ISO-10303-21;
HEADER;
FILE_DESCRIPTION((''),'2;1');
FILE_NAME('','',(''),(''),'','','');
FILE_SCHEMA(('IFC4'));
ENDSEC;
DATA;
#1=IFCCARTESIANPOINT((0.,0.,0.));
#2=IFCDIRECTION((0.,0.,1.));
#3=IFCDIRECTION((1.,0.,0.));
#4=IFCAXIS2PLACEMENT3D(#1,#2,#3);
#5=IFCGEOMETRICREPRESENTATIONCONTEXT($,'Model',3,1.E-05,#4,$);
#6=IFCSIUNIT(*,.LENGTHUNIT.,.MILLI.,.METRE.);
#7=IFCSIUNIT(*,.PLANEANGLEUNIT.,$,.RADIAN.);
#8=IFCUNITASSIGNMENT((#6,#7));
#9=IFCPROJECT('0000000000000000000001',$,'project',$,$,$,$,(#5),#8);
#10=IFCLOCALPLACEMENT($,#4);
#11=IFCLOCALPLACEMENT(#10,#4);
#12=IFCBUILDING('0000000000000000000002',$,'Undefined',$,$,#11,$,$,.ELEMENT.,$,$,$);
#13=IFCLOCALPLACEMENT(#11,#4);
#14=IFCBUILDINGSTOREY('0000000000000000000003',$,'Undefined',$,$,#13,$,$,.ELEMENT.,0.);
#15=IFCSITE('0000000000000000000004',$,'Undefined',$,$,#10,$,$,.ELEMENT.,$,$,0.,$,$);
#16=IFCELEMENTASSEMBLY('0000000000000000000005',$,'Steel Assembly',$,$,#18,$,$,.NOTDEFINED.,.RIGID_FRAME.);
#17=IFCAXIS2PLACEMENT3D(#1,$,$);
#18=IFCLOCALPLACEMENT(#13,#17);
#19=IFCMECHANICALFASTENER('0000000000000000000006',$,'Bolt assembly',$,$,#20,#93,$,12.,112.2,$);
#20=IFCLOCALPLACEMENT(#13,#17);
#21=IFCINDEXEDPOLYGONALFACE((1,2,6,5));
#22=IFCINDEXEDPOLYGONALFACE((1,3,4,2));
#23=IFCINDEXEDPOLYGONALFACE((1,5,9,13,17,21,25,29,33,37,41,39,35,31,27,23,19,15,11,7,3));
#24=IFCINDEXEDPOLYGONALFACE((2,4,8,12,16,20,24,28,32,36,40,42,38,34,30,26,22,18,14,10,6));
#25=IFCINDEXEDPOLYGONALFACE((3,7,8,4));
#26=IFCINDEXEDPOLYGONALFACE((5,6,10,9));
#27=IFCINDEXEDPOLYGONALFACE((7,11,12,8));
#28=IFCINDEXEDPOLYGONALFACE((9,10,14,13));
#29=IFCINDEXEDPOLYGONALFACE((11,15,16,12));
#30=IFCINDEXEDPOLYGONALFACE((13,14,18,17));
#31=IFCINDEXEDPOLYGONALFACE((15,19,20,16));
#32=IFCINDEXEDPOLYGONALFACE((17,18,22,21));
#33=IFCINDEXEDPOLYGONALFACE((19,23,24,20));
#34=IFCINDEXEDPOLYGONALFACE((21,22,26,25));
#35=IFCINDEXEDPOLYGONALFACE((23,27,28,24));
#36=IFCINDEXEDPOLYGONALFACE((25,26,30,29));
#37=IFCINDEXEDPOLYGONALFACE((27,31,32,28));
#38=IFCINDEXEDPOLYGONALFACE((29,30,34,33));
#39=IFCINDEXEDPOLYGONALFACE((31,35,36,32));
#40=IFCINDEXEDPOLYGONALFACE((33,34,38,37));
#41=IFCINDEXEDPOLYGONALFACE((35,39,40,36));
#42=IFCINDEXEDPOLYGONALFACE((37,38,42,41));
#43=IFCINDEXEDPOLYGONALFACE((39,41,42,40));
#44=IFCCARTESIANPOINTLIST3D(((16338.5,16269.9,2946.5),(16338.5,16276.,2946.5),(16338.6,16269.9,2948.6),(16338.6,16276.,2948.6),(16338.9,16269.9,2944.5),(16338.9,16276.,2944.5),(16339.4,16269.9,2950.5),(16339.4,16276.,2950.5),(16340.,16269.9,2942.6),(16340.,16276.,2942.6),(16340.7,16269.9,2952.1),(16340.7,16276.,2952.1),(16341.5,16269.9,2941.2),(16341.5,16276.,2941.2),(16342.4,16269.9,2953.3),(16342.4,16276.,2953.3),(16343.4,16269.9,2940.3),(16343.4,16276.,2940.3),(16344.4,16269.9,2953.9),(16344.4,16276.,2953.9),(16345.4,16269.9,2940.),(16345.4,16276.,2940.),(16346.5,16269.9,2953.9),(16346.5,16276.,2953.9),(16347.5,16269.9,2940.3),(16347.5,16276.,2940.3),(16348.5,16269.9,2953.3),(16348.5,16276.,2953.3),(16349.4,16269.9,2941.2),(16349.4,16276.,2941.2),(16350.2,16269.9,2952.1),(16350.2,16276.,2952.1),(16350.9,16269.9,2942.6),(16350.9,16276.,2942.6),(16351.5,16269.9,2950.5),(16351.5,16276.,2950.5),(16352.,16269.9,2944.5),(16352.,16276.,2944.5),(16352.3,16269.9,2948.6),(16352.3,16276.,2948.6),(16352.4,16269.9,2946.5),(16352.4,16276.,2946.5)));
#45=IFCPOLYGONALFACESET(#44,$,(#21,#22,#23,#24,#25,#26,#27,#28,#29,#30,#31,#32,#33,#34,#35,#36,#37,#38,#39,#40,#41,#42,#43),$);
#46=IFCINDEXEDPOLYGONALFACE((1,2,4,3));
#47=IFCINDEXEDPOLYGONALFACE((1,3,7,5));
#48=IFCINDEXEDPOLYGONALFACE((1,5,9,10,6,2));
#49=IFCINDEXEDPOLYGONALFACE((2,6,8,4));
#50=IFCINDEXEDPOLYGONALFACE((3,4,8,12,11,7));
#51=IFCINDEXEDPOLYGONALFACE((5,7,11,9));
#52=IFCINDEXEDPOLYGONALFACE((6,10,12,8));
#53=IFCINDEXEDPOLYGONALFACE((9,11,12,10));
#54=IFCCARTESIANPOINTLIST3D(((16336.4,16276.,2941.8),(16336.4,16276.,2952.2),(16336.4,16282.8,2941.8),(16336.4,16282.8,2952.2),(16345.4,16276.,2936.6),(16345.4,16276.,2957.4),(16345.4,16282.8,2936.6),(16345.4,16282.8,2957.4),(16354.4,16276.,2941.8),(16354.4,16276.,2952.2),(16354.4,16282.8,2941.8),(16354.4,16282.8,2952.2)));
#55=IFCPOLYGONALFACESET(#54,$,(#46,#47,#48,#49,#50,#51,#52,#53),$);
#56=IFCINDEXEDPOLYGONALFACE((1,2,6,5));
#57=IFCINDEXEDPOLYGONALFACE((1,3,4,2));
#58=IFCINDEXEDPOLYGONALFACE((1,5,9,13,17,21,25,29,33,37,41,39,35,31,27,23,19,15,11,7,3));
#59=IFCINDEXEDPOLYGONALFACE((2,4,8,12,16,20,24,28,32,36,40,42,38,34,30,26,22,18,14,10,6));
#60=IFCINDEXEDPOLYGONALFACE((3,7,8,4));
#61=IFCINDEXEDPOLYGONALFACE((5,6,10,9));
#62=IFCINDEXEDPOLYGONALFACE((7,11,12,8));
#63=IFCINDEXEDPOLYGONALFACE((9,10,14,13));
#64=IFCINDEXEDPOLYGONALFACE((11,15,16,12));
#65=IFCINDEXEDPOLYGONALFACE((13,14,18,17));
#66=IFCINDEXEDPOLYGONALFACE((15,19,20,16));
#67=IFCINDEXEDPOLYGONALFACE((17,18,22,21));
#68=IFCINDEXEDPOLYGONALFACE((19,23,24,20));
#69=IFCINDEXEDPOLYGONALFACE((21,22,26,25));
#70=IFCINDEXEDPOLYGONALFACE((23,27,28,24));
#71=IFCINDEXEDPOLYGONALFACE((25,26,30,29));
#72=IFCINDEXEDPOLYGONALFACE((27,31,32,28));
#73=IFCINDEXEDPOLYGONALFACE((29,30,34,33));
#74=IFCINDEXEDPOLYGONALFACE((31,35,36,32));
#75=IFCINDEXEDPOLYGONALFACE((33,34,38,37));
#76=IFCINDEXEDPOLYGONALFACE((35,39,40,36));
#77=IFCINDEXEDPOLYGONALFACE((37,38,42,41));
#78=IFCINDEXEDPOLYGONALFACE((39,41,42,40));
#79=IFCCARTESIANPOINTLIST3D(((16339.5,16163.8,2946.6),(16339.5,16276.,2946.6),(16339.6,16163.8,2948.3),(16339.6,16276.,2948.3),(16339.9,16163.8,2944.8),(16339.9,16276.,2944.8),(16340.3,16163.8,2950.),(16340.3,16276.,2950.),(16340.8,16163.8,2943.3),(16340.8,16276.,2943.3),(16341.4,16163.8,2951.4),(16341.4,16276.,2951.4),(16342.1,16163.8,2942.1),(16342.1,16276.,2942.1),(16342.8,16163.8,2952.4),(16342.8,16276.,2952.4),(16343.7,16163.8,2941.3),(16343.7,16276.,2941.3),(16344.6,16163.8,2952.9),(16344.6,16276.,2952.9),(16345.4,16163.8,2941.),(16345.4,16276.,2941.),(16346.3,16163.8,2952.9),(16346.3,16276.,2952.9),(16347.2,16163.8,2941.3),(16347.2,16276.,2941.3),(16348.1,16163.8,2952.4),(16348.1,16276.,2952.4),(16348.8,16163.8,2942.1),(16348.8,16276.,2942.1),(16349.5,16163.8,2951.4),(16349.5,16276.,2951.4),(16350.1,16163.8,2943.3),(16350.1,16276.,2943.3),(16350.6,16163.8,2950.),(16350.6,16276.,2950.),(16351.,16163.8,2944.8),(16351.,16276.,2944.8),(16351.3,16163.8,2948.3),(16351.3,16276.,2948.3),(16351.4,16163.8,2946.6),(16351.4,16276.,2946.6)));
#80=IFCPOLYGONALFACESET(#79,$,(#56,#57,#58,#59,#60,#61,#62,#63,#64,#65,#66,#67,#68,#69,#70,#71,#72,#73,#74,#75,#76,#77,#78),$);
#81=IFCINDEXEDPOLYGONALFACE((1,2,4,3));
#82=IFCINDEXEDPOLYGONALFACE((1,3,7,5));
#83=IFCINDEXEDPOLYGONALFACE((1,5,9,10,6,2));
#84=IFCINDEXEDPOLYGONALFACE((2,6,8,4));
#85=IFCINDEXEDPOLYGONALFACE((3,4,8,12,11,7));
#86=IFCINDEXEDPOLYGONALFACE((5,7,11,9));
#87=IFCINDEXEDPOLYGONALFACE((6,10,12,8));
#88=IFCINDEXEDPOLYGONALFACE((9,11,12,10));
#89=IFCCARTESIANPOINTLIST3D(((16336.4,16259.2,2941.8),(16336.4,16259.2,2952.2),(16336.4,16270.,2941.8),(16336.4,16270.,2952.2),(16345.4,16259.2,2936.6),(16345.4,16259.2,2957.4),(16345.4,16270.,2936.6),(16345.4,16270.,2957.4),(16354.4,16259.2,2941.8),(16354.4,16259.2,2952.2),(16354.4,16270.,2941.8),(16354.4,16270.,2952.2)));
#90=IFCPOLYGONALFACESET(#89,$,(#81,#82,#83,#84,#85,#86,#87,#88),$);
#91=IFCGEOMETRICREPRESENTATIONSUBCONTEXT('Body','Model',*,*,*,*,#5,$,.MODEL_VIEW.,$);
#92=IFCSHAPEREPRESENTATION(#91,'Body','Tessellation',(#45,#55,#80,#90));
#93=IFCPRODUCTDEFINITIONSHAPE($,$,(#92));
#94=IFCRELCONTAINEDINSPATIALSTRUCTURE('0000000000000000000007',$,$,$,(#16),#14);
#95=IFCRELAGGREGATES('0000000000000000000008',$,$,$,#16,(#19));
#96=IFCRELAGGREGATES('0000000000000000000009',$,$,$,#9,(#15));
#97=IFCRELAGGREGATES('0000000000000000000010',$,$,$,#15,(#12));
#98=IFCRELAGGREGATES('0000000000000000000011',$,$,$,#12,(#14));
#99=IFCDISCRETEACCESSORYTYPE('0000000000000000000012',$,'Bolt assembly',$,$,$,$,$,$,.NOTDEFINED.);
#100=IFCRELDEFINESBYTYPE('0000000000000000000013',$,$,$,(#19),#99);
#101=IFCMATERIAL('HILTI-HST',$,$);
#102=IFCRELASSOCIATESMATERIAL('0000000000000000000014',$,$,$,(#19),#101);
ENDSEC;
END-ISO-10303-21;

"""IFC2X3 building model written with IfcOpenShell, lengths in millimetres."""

from ifc_helpers import new_model, si_unit, frame, origin_with_axes, origin_2d_with_axis, place, context, subcontext, project, spatial, polyline, circle, outline, extrude, source, transform, mapped, material, type_object, element, aggregate, save


model = new_model("IFC2X3")

# Units and contexts
model_context = context("Model", 3, precision=1e-05, world=origin_with_axes())
body_context = subcontext(model_context, "Body", "Model", "MODEL_VIEW")
ifc_project = project(units=[si_unit("LENGTHUNIT", "METRE", prefix="MILLI"), si_unit("PLANEANGLEUNIT", "RADIAN")], contexts=[model_context])

# Site, building, storey
site_placement = place(None, origin_with_axes())
site = spatial("IfcSite", under=ifc_project, at=site_placement, Name="Undefined", CompositionType="ELEMENT", RefElevation=0.0)
building_placement = place(site_placement, origin_with_axes())
building = spatial("IfcBuilding", under=site, at=building_placement, Name="Undefined", CompositionType="ELEMENT")
storey_placement = place(building_placement, origin_with_axes())
storey = spatial("IfcBuildingStorey", under=building, at=storey_placement, Name="Undefined", CompositionType="ELEMENT", Elevation=0.0)

# Shared definitions
discrete_accessory_type_1 = type_object("IfcDiscreteAccessoryType", Name="Bolt assembly")

# Element assembly, mechanical fastener
assembly_1_placement = place(storey_placement, origin_with_axes())
assembly_1 = element("IfcElementAssembly", 1, at=assembly_1_placement, inside=storey, Name="Steel Assembly", AssemblyPlace="NOTDEFINED", PredefinedType="RIGID_FRAME")
ifc_material_1 = material(Name="HILTI-HST")
shared_shape_1 = source(origin_with_axes(), body_context, "Body", "SweptSolid", [
    extrude(circle(Radius=7.0, at=origin_2d_with_axis()), frame((0.0, 0.0, 0.0), z_axis=(0.0, 1.0, 0.0), x_axis=(1.0, 0.0, 0.0)), (0.0, 0.0, 1.0), 6.1),
    extrude(outline(polyline([(10.4, 0.0), (5.2, 9.0), (-5.2, 9.0), (-10.4, 0.0), (-5.2, -9.0), (5.2, -9.0), (10.4, 0.0)])), frame((0.0, -6.8, 0.0), z_axis=(0.0, 1.0, 0.0), x_axis=(1.0, 0.0, 0.0)), (0.0, 0.0, 1.0), 6.8),
    extrude(circle(Radius=6.0, at=origin_2d_with_axis()), frame((0.0, 0.0, 0.0), z_axis=(0.0, 1.0, 0.0), x_axis=(1.0, 0.0, 0.0)), (0.0, 0.0, 1.0), 112.2),
    extrude(outline(polyline([(10.4, 0.0), (5.2, 9.0), (-5.2, 9.0), (-10.4, 0.0), (-5.2, -9.0), (5.2, -9.0), (10.4, 0.0)])), frame((0.0, 6.0, 0.0), z_axis=(0.0, 1.0, 0.0), x_axis=(1.0, 0.0, 0.0)), (0.0, 0.0, 1.0), 10.8),
])
mechanical_fastener_1_placement = place(assembly_1_placement, frame((16345.5, 16276.0, 2947.0), z_axis=(-1.0, 0.0, 0.0), x_axis=(0.0, 0.0, -1.0)))
mechanical_fastener_1 = element("IfcMechanicalFastener", 2, at=mechanical_fastener_1_placement, type_object=discrete_accessory_type_1, material=ifc_material_1, Name="Bolt assembly", NominalDiameter=12.0, NominalLength=112.2, context=body_context, shape_type="MappedRepresentation", body=[
    mapped(shared_shape_1, transform((0.0, 0.0, 0.0))),
])
aggregate(assembly_1, [mechanical_fastener_1])

save(model, "model.ifc")
